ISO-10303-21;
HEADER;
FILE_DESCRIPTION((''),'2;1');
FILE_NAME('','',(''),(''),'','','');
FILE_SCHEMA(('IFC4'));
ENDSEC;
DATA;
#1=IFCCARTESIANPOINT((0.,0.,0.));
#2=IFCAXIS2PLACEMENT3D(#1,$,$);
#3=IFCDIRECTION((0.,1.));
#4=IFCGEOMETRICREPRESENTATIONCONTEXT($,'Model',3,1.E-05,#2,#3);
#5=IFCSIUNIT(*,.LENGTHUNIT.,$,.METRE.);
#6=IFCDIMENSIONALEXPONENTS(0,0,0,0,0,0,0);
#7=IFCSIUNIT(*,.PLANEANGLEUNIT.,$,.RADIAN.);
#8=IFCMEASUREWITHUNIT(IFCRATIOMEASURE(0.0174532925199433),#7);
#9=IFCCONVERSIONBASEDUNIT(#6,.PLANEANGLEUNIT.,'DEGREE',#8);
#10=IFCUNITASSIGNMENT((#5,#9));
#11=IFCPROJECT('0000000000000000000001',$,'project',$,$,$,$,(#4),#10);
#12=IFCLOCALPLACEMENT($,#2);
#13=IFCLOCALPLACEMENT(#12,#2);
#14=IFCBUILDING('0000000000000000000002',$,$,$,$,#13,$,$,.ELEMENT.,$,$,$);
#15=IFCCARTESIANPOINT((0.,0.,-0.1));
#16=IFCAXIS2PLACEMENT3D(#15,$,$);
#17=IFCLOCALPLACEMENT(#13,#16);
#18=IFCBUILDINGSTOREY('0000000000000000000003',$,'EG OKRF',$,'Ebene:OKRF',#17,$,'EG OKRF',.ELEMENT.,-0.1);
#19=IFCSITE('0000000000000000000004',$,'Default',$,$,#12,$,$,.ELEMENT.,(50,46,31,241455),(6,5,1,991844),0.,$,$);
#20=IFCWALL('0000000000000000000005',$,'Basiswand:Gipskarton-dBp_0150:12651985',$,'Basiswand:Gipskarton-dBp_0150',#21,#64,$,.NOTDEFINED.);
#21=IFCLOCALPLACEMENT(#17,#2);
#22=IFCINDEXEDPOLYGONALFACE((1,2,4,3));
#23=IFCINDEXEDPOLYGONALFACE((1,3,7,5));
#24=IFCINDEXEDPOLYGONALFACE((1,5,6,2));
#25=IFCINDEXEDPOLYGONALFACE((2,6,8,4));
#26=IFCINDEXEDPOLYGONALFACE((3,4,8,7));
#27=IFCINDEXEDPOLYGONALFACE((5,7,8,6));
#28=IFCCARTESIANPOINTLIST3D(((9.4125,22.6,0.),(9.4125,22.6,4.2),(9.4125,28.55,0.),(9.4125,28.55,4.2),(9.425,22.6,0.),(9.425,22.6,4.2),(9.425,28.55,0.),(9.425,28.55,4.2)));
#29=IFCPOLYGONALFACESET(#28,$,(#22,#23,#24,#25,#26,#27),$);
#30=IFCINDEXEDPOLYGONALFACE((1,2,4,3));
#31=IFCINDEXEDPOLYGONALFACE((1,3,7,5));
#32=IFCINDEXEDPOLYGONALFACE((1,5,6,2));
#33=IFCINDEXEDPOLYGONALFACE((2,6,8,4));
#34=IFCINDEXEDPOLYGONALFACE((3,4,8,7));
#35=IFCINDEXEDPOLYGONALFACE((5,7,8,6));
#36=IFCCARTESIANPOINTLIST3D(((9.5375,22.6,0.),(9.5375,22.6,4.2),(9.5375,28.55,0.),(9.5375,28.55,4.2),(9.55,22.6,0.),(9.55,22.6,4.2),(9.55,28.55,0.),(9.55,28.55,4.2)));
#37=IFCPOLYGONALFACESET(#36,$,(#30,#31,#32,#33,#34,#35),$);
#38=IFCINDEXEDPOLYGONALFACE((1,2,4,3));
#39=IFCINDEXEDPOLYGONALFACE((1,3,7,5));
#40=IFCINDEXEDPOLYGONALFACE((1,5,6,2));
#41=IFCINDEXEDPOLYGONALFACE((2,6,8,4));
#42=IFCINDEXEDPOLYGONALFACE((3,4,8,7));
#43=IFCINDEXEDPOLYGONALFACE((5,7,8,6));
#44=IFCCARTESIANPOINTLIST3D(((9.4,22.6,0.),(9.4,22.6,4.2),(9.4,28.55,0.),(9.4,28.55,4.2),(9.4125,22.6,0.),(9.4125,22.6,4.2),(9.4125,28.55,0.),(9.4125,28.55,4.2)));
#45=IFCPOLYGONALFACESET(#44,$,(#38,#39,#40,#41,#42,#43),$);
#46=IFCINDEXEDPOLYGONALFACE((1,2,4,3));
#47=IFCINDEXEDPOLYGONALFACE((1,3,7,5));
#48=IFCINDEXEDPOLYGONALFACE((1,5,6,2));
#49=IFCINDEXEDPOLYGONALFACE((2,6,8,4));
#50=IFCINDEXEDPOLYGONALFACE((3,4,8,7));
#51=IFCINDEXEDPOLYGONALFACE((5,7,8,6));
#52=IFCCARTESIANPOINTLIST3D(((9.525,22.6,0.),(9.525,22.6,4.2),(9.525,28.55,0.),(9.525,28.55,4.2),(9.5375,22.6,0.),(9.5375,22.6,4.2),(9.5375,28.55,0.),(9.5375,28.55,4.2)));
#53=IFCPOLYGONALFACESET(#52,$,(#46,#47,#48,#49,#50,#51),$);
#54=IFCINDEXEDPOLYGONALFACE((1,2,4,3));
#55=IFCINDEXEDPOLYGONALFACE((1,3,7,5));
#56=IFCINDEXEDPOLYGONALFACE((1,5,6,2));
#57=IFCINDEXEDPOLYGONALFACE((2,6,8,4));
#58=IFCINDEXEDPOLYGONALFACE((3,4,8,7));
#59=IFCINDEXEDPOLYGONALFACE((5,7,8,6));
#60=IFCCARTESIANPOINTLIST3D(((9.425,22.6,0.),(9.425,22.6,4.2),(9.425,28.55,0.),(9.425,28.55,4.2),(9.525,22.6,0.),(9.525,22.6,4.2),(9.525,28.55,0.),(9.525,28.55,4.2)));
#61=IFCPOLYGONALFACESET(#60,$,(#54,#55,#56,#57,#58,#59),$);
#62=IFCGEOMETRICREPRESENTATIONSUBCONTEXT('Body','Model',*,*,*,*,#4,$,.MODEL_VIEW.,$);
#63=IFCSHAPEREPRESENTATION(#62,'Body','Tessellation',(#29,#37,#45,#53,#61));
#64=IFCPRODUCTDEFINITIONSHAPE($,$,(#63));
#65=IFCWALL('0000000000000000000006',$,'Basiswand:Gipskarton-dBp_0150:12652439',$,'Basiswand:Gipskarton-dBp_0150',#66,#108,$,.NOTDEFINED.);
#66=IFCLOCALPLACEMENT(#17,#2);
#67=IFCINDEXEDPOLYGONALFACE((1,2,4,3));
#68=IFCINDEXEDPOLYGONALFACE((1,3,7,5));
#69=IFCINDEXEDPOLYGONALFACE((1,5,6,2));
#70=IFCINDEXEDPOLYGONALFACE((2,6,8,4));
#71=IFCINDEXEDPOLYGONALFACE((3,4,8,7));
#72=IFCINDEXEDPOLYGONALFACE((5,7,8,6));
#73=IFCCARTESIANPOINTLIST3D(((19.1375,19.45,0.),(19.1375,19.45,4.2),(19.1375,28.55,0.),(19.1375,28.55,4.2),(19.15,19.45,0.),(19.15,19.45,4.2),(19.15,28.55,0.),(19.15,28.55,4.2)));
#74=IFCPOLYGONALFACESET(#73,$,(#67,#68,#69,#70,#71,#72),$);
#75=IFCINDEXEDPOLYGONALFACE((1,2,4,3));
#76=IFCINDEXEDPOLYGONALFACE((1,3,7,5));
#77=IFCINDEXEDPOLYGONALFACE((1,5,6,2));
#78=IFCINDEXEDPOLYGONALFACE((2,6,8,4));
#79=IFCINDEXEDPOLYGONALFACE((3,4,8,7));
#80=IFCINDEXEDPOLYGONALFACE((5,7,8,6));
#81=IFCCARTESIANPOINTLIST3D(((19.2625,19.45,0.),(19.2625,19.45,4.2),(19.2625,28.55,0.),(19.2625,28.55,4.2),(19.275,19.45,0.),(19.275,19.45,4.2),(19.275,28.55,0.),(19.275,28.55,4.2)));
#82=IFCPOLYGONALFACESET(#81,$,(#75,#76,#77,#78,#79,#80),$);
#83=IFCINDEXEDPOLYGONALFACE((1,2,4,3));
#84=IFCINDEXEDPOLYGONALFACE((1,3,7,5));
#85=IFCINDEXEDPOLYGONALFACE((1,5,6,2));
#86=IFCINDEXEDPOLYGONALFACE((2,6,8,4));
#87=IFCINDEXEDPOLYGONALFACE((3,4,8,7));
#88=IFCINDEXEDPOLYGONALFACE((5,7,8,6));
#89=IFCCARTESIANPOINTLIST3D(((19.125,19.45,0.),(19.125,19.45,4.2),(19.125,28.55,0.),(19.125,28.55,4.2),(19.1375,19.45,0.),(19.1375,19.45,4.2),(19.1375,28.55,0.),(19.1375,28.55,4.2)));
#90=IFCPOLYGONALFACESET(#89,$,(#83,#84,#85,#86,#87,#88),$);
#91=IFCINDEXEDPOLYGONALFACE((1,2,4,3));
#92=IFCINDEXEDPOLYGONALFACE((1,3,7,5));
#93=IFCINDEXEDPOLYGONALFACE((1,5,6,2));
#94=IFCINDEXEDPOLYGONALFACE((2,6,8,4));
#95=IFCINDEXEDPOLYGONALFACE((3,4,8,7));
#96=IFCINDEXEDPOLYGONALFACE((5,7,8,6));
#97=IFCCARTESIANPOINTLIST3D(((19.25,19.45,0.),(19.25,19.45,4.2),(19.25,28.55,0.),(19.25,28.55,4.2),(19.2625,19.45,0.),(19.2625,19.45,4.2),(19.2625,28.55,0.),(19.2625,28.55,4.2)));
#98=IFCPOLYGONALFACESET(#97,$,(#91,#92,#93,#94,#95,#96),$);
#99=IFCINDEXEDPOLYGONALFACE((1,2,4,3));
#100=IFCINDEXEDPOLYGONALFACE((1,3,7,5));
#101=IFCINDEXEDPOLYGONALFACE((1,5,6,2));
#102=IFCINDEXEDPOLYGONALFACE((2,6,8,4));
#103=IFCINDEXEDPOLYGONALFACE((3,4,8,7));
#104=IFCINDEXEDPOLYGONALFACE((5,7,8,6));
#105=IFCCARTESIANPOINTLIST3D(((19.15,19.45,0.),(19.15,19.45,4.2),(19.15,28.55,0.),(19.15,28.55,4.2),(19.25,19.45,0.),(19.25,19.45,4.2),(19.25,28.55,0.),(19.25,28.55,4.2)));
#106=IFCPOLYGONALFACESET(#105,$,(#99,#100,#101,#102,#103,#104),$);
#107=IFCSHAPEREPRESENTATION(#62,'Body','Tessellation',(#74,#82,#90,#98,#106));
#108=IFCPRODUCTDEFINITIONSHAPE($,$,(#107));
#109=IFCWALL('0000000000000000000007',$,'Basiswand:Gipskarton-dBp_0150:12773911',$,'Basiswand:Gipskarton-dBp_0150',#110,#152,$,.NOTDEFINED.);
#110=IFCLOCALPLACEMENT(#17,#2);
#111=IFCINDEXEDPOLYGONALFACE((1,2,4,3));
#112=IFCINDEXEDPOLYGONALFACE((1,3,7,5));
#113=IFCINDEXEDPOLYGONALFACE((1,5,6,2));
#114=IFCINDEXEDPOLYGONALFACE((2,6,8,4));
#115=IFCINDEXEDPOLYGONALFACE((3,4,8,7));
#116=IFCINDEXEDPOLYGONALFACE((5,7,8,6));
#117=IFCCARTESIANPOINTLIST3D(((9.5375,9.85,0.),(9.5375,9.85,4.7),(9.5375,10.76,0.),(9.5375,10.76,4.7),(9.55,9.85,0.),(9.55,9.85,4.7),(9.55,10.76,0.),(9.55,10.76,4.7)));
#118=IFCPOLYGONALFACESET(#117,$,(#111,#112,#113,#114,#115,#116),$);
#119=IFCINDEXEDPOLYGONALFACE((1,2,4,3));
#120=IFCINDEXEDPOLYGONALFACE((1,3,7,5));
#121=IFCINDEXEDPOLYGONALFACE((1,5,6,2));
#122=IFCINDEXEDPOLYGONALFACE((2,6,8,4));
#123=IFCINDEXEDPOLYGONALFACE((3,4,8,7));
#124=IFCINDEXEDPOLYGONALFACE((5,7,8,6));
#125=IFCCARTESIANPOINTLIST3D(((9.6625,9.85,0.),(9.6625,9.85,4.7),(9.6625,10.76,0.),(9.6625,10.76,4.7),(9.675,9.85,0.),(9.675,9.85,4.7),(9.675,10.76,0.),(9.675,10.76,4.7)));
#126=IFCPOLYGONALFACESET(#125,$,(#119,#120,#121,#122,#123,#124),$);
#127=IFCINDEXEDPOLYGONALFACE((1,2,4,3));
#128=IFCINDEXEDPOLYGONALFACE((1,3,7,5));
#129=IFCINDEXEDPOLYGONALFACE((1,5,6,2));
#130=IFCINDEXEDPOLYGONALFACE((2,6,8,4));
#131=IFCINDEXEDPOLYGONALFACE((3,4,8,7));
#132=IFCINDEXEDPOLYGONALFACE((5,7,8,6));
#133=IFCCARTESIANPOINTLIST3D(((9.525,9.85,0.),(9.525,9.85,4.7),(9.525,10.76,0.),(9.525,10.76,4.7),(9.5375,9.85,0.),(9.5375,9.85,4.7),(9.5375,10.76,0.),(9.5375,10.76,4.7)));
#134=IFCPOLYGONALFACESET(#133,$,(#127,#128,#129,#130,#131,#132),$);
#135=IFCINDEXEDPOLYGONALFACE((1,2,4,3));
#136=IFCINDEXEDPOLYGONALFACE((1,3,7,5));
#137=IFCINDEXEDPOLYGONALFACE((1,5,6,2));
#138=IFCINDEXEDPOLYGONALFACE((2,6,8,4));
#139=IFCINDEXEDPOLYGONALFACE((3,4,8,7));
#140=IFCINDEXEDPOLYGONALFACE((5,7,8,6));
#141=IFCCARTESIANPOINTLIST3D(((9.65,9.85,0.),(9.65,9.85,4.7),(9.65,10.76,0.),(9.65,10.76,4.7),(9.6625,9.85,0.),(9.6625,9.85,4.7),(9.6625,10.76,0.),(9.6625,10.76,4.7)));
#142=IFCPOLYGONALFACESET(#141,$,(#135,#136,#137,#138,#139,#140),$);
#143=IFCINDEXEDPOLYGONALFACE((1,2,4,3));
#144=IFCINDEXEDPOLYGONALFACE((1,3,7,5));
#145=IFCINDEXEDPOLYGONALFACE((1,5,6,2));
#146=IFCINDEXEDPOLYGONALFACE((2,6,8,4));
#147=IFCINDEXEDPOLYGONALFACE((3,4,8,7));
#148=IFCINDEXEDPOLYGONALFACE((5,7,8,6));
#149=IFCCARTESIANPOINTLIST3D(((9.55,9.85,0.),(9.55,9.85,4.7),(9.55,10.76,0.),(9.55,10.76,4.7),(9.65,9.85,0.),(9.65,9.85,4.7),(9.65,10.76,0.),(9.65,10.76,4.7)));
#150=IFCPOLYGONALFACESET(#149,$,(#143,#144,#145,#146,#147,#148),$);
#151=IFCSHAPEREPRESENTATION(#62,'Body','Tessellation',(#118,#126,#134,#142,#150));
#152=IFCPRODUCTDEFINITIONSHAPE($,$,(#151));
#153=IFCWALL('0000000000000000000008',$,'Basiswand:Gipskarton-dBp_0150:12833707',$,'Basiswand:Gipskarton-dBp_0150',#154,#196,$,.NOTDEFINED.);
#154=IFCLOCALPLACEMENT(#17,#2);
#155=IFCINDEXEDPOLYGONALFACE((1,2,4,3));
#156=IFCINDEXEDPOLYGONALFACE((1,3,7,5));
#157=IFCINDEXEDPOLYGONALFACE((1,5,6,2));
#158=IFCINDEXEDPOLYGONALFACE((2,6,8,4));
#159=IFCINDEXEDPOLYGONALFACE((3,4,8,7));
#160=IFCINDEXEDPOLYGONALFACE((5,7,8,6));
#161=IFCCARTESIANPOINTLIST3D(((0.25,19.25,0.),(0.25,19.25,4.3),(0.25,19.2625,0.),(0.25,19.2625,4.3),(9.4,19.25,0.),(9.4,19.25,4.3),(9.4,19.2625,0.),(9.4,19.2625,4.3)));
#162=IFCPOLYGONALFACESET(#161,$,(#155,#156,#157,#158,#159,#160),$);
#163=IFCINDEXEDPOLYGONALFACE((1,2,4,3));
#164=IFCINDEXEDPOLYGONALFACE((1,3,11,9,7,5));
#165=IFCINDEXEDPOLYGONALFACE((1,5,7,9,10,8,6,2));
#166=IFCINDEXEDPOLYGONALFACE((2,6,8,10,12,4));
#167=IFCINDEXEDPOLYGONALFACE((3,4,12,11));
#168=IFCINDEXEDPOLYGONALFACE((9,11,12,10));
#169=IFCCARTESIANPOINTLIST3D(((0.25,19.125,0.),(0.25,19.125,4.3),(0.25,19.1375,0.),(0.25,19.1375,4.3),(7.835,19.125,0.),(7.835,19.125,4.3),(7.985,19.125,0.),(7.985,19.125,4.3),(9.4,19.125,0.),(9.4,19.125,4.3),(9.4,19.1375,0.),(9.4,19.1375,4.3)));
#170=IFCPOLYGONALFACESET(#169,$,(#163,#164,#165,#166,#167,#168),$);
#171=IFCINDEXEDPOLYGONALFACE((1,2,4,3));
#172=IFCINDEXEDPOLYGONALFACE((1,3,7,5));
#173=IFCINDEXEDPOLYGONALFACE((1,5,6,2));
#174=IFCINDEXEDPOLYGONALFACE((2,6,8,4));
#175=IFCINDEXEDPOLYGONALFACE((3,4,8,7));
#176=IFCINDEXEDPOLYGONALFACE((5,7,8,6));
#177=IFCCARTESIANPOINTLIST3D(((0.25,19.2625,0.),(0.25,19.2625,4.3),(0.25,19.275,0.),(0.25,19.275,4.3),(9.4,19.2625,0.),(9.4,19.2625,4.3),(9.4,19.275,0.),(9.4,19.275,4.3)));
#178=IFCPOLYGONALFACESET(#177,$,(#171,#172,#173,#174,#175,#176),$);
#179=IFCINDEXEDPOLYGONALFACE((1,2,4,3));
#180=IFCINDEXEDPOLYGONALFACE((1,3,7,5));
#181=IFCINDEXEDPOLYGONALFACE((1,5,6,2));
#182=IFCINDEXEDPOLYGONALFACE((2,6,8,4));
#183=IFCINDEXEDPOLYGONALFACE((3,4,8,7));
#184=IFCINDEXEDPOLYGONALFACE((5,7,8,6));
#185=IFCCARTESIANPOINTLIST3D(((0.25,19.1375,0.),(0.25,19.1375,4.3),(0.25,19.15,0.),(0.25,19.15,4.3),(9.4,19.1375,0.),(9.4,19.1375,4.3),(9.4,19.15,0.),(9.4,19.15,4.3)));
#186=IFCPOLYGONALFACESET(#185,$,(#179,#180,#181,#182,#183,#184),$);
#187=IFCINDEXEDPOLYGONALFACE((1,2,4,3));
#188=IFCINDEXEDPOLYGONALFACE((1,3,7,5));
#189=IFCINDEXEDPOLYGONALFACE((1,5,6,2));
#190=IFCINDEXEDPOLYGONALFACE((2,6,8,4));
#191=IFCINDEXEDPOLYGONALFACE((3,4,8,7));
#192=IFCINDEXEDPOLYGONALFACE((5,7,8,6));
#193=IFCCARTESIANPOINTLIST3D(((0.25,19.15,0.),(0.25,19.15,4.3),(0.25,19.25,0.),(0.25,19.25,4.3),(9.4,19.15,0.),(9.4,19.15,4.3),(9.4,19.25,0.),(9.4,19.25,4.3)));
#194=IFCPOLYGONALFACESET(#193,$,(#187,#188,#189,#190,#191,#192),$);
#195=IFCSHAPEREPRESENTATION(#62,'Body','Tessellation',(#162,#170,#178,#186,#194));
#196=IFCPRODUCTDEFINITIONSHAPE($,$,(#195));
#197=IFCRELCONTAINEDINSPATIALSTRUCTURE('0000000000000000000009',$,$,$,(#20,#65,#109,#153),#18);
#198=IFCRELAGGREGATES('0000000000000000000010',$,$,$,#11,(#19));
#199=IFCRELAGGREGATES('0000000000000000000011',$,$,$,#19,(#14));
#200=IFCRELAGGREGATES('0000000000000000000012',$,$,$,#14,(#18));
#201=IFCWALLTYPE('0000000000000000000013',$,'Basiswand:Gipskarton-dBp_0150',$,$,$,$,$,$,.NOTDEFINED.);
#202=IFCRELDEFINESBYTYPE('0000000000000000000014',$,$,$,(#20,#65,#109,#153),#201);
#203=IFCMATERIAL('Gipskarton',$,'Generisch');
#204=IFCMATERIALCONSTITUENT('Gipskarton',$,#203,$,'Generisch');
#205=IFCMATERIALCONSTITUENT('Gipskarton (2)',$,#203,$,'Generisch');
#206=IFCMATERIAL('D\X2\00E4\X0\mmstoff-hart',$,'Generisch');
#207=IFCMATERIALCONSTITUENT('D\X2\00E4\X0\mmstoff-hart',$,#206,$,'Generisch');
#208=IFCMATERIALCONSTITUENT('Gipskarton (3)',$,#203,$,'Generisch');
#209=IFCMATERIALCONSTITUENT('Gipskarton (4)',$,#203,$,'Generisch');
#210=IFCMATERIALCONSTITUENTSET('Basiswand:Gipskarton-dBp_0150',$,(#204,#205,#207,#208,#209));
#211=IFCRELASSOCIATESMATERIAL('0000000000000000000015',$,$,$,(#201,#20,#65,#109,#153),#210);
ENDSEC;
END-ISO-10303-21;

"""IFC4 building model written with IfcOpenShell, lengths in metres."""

from ifc_helpers import new_model, entity, si_unit, converted_unit, direction, frame, origin, place, context, subcontext, project, spatial, indexed_curve, outline, extrude, material, constituent, constituent_set, type_object, element, save


model = new_model("IFC4")

# Units and contexts
model_context = context("Model", 3, precision=1e-05, world=origin(), true_north=direction((0.0, 1.0)))
body_context = subcontext(model_context, "Body", "Model", "MODEL_VIEW")
ifc_project = project(units=[si_unit("LENGTHUNIT", "METRE"), converted_unit("PLANEANGLEUNIT", "DEGREE", entity("IfcRatioMeasure", 0.0174532925199433), si_unit("PLANEANGLEUNIT", "RADIAN"), dimensions=[0, 0, 0, 0, 0, 0, 0])], contexts=[model_context])

# Site, building, storey
site_placement = place(None, origin())
site = spatial("IfcSite", under=ifc_project, at=site_placement, Name="Default", CompositionType="ELEMENT", RefLatitude=(50, 46, 31, 241455), RefLongitude=(6, 5, 1, 991844), RefElevation=0.0)
building_placement = place(site_placement, origin())
building = spatial("IfcBuilding", under=site, at=building_placement, CompositionType="ELEMENT")
storey_placement = place(building_placement, frame((0.0, 0.0, -0.1)))
storey = spatial("IfcBuildingStorey", under=building, at=storey_placement, Name="EG OKRF", ObjectType="Ebene:OKRF", LongName="EG OKRF", CompositionType="ELEMENT", Elevation=-0.1)

# Walls
ifc_material_1 = material(Name="Gipskarton", Category="Generisch")
ifc_constituent_1 = constituent(ifc_material_1, Name="Gipskarton", Category="Generisch")
ifc_constituent_2 = constituent(ifc_material_1, Name="Gipskarton (2)", Category="Generisch")
ifc_material_2 = material(Name="Dämmstoff-hart", Category="Generisch")
ifc_constituent_3 = constituent(ifc_material_2, Name="Dämmstoff-hart", Category="Generisch")
ifc_constituent_4 = constituent(ifc_material_1, Name="Gipskarton (3)", Category="Generisch")
ifc_constituent_5 = constituent(ifc_material_1, Name="Gipskarton (4)", Category="Generisch")
ifc_constituent_set_1 = constituent_set(constituents=[ifc_constituent_1, ifc_constituent_2, ifc_constituent_3, ifc_constituent_4, ifc_constituent_5], Name="Basiswand:Gipskarton-dBp_0150")
wall_type_1 = type_object("IfcWallType", Name="Basiswand:Gipskarton-dBp_0150", PredefinedType="NOTDEFINED", material=ifc_constituent_set_1)
wall_1_placement = place(storey_placement, frame((9.475, 28.55, 0.0), z_axis=(0.0, 0.0, 1.0), x_axis=(0.0, -1.0, 0.0)))
element("IfcWall", 1, at=wall_1_placement, inside=storey, type_object=wall_type_1, material=ifc_constituent_set_1, Name="Basiswand:Gipskarton-dBp_0150:12651985", ObjectType="Basiswand:Gipskarton-dBp_0150", PredefinedType="NOTDEFINED", context=body_context, shape_type="SweptSolid", body=[
    extrude(outline(indexed_curve([(-2.975, -0.0062), (2.975, -0.0062), (2.975, 0.0063), (-2.975, 0.0063), (-2.975, -0.0062)], self_intersect=False)), frame((2.975, -0.0563, 0.0)), (0.0, 0.0, 1.0), 4.2),
    extrude(outline(indexed_curve([(-0.0063, -2.975), (0.0062, -2.975), (0.0063, 2.975), (-0.0062, 2.975), (-0.0063, -2.975)], self_intersect=False)), frame((2.975, 0.0688, 0.0), z_axis=(0.0, 0.0, 1.0), x_axis=(0.0, -1.0, 0.0)), (0.0, 0.0, 1.0), 4.2),
    extrude(outline(indexed_curve([(-0.0063, -2.975), (0.0062, -2.975), (0.0063, 2.975), (-0.0062, 2.975), (-0.0063, -2.975)], self_intersect=False)), frame((2.975, -0.0687, 0.0), z_axis=(0.0, 0.0, 1.0), x_axis=(0.0, 1.0, 0.0)), (0.0, 0.0, 1.0), 4.2),
    extrude(outline(indexed_curve([(-2.975, -0.0062), (2.975, -0.0062), (2.975, 0.0063), (-2.975, 0.0063), (-2.975, -0.0062)], self_intersect=False)), frame((2.975, 0.0563, 0.0)), (0.0, 0.0, 1.0), 4.2),
    extrude(outline(indexed_curve([(-2.975, -0.05), (2.975, -0.05), (2.975, 0.05), (-2.975, 0.05), (-2.975, -0.05)], self_intersect=False)), frame((2.975, 0.0, 0.0)), (0.0, 0.0, 1.0), 4.2),
])
wall_2_placement = place(storey_placement, frame((19.2, 28.55, 0.0), z_axis=(0.0, 0.0, 1.0), x_axis=(0.0, -1.0, 0.0)))
element("IfcWall", 2, at=wall_2_placement, inside=storey, type_object=wall_type_1, material=ifc_constituent_set_1, Name="Basiswand:Gipskarton-dBp_0150:12652439", ObjectType="Basiswand:Gipskarton-dBp_0150", PredefinedType="NOTDEFINED", context=body_context, shape_type="SweptSolid", body=[
    extrude(outline(indexed_curve([(-4.55, -0.0063), (4.55, -0.0063), (4.55, 0.0062), (-4.55, 0.0062), (-4.55, -0.0063)], self_intersect=False)), frame((4.55, -0.0562, 0.0)), (0.0, 0.0, 1.0), 4.2),
    extrude(outline(indexed_curve([(-0.0063, -4.55), (0.0062, -4.55), (0.0063, 4.55), (-0.0062, 4.55), (-0.0063, -4.55)], self_intersect=False)), frame((4.55, 0.0688, 0.0), z_axis=(0.0, 0.0, 1.0), x_axis=(0.0, -1.0, 0.0)), (0.0, 0.0, 1.0), 4.2),
    extrude(outline(indexed_curve([(-0.0063, -4.55), (0.0062, -4.55), (0.0063, 4.55), (-0.0062, 4.55), (-0.0063, -4.55)], self_intersect=False)), frame((4.55, -0.0688, 0.0), z_axis=(0.0, 0.0, 1.0), x_axis=(0.0, 1.0, 0.0)), (0.0, 0.0, 1.0), 4.2),
    extrude(outline(indexed_curve([(-4.55, -0.0063), (4.55, -0.0063), (4.55, 0.0062), (-4.55, 0.0062), (-4.55, -0.0063)], self_intersect=False)), frame((4.55, 0.0563, 0.0)), (0.0, 0.0, 1.0), 4.2),
    extrude(outline(indexed_curve([(-4.55, -0.05), (4.55, -0.05), (4.55, 0.05), (-4.55, 0.05), (-4.55, -0.05)], self_intersect=False)), frame((4.55, 0.0, 0.0)), (0.0, 0.0, 1.0), 4.2),
])

# Walls
wall_3_placement = place(storey_placement, frame((9.6, 10.76, 0.0), z_axis=(0.0, 0.0, 1.0), x_axis=(0.0, -1.0, 0.0)))
element("IfcWall", 3, at=wall_3_placement, inside=storey, type_object=wall_type_1, material=ifc_constituent_set_1, Name="Basiswand:Gipskarton-dBp_0150:12773911", ObjectType="Basiswand:Gipskarton-dBp_0150", PredefinedType="NOTDEFINED", context=body_context, shape_type="SweptSolid", body=[
    extrude(outline(indexed_curve([(-0.455, -0.0062), (0.455, -0.0062), (0.455, 0.0063), (-0.455, 0.0063), (-0.455, -0.0062)], self_intersect=False)), frame((0.455, -0.0563, 0.0)), (0.0, 0.0, 1.0), 4.7),
    extrude(outline(indexed_curve([(-0.0063, -0.455), (0.0062, -0.455), (0.0063, 0.455), (-0.0062, 0.455), (-0.0063, -0.455)], self_intersect=False)), frame((0.455, 0.0688, 0.0), z_axis=(0.0, 0.0, 1.0), x_axis=(0.0, -1.0, 0.0)), (0.0, 0.0, 1.0), 4.7),
    extrude(outline(indexed_curve([(-0.0062, -0.455), (0.0062, -0.455), (0.0063, 0.455), (-0.0062, 0.455), (-0.0062, -0.455)], self_intersect=False)), frame((0.455, -0.0687, 0.0), z_axis=(0.0, 0.0, 1.0), x_axis=(0.0, 1.0, 0.0)), (0.0, 0.0, 1.0), 4.7),
    extrude(outline(indexed_curve([(-0.455, -0.0062), (0.455, -0.0062), (0.455, 0.0063), (-0.455, 0.0063), (-0.455, -0.0062)], self_intersect=False)), frame((0.455, 0.0563, 0.0)), (0.0, 0.0, 1.0), 4.7),
    extrude(outline(indexed_curve([(-0.455, -0.05), (0.455, -0.05), (0.455, 0.05), (-0.455, 0.05), (-0.455, -0.05)], self_intersect=False)), frame((0.455, 0.0, 0.0)), (0.0, 0.0, 1.0), 4.7),
])
wall_4_placement = place(storey_placement, frame((9.4, 19.2, 0.0), z_axis=(0.0, 0.0, 1.0), x_axis=(-1.0, 0.0, 0.0)))
element("IfcWall", 4, at=wall_4_placement, inside=storey, type_object=wall_type_1, material=ifc_constituent_set_1, Name="Basiswand:Gipskarton-dBp_0150:12833707", ObjectType="Basiswand:Gipskarton-dBp_0150", PredefinedType="NOTDEFINED", context=body_context, shape_type="SweptSolid", body=[
    extrude(outline(indexed_curve([(-4.575, -0.0063), (4.575, -0.0063), (4.575, 0.0063), (-4.575, 0.0063), (-4.575, -0.0063)], self_intersect=False)), frame((4.575, -0.0563, 0.0)), (0.0, 0.0, 1.0), 4.3),
    extrude(outline(indexed_curve([(1.9817, -0.0042), (2.1317, -0.0042), (3.5467, -0.0042), (3.5467, 0.0083), (-5.6033, 0.0083), (-5.6033, -0.0042), (1.9817, -0.0042)], self_intersect=False)), frame((3.5467, 0.0708, 0.0), z_axis=(0.0, 0.0, 1.0), x_axis=(-1.0, 0.0, 0.0)), (0.0, 0.0, 1.0), 4.3),
    extrude(outline(indexed_curve([(-0.0063, -4.575), (0.0062, -4.575), (0.0063, 4.575), (-0.0062, 4.575), (-0.0063, -4.575)], self_intersect=False)), frame((4.575, -0.0687, 0.0), z_axis=(0.0, 0.0, 1.0), x_axis=(0.0, 1.0, 0.0)), (0.0, 0.0, 1.0), 4.3),
    extrude(outline(indexed_curve([(-4.575, -0.0063), (4.575, -0.0063), (4.575, 0.0063), (-4.575, 0.0063), (-4.575, -0.0063)], self_intersect=False)), frame((4.575, 0.0563, 0.0)), (0.0, 0.0, 1.0), 4.3),
    extrude(outline(indexed_curve([(-4.575, -0.05), (4.575, -0.05), (4.575, 0.05), (-4.575, 0.05), (-4.575, -0.05)], self_intersect=False)), frame((4.575, 0.0, 0.0)), (0.0, 0.0, 1.0), 4.3),
])

save(model, "model.ifc")
